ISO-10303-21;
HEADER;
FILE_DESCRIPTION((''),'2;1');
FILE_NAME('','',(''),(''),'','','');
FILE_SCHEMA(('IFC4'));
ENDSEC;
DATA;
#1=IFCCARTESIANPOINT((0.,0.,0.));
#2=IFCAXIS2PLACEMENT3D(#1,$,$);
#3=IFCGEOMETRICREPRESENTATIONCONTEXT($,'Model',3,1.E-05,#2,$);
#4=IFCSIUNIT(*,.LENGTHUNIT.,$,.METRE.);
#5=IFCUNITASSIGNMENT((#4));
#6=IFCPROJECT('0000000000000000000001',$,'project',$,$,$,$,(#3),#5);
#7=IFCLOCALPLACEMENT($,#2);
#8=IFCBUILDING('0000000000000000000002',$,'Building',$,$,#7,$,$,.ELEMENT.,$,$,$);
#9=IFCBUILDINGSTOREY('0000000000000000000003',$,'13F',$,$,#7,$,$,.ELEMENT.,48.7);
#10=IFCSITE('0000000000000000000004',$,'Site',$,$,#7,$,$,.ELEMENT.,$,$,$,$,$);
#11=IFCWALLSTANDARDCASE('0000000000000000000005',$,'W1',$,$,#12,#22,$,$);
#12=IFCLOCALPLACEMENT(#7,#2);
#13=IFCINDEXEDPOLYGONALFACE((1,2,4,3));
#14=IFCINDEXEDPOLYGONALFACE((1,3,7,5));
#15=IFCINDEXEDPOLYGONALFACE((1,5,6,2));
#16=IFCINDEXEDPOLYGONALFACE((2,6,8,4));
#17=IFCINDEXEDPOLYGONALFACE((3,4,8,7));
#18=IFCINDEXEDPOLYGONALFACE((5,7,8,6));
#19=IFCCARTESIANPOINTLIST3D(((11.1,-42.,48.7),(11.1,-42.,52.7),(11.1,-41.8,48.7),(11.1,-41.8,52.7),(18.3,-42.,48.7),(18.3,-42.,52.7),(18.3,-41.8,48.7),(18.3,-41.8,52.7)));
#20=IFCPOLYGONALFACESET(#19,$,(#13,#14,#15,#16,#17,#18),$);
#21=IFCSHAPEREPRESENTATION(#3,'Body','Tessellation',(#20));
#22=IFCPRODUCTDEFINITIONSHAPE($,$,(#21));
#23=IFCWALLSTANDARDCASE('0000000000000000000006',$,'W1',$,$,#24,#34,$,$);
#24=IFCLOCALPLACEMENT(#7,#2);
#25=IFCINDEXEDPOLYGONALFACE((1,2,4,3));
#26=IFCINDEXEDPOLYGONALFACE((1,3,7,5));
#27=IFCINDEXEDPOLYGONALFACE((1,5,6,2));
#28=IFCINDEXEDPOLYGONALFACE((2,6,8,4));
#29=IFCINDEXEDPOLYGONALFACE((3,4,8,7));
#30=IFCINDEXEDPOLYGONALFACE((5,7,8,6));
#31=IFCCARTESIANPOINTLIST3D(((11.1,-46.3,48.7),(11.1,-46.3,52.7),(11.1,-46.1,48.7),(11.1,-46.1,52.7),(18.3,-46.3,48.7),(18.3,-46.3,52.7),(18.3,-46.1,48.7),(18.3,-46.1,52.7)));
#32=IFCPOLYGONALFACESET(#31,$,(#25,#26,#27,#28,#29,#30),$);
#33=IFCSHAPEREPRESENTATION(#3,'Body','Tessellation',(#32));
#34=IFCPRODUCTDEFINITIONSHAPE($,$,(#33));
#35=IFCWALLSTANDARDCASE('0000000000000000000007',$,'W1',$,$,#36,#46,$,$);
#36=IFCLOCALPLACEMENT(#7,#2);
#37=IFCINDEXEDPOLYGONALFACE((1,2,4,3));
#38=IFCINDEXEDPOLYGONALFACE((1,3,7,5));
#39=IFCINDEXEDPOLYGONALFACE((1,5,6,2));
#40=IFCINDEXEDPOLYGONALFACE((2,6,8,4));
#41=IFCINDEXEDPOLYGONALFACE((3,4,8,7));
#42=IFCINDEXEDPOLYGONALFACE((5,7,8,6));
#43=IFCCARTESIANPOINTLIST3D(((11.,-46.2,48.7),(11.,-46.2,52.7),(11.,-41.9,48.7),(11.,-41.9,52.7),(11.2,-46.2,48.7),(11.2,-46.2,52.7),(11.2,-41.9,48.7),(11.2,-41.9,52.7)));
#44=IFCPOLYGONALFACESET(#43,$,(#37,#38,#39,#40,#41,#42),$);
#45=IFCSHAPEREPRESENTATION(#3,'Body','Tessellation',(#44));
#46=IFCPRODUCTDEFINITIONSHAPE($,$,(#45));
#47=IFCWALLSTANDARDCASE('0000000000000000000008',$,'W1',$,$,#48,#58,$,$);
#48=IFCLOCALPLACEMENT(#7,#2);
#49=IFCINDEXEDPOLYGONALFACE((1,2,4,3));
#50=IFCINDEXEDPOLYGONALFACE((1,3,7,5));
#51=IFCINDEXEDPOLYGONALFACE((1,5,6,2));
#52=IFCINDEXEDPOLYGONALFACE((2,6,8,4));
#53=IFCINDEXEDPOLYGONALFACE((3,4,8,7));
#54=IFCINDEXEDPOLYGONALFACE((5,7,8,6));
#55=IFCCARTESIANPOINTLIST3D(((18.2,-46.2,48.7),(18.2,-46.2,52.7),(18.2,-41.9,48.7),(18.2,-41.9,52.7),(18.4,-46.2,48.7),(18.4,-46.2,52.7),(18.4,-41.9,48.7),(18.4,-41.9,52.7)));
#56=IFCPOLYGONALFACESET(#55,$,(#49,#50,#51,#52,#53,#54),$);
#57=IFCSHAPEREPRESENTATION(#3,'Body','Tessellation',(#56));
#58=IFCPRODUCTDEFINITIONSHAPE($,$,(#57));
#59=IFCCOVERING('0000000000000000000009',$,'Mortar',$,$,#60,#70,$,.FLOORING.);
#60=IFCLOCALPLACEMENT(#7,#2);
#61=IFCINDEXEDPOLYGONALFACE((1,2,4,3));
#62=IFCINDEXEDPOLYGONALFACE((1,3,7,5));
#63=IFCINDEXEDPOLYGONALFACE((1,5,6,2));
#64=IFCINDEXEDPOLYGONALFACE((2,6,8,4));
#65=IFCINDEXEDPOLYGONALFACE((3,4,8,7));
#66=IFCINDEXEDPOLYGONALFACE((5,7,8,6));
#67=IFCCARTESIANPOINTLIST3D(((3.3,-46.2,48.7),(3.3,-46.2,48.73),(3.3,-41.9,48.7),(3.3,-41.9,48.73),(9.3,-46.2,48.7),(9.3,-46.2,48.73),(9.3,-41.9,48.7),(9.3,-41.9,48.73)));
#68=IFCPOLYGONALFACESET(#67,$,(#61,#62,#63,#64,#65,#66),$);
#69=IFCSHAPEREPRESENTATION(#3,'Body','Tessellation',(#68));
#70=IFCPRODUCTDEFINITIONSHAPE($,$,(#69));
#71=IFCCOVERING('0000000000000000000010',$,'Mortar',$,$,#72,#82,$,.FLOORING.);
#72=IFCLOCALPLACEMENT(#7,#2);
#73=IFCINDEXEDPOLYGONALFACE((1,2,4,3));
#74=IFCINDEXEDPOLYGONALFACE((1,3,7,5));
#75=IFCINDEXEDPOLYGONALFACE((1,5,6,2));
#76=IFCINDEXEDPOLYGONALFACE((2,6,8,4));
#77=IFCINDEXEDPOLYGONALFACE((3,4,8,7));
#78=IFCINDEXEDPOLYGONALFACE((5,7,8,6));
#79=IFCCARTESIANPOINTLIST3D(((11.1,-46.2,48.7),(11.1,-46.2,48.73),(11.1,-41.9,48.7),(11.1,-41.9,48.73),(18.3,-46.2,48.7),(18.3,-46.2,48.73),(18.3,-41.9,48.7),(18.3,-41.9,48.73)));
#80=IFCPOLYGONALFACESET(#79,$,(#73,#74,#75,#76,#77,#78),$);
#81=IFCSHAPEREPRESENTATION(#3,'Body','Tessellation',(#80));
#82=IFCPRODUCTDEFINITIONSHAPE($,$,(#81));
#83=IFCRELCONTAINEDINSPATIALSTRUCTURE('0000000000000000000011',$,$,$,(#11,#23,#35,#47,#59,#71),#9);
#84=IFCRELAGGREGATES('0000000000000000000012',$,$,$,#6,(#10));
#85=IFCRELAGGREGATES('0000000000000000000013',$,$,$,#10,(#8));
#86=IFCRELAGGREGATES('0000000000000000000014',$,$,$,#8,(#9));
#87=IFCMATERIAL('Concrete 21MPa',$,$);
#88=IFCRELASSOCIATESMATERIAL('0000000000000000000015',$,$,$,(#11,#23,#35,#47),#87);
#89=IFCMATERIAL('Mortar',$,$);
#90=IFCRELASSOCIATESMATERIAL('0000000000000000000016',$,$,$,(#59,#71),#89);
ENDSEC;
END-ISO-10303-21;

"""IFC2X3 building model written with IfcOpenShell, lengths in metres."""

from ifc_helpers import new_model, si_unit, frame, origin, origin_2d, place, context, project, spatial, rectangle, extrude, material, element, save


model = new_model("IFC2X3")

# Units and contexts
model_context = context("Model", 3, precision=1e-05, world=origin())
ifc_project = project(units=[si_unit("LENGTHUNIT", "METRE")], contexts=[model_context])

# Site, building, storey
placement = place(None, origin())
site = spatial("IfcSite", under=ifc_project, at=placement, Name="Site", CompositionType="ELEMENT")
building = spatial("IfcBuilding", under=site, at=placement, Name="Building", CompositionType="ELEMENT")
storey = spatial("IfcBuildingStorey", under=building, at=placement, Name="13F", CompositionType="ELEMENT", Elevation=48.7)

# Shared definitions
ifc_material_1 = material(Name="Concrete 21MPa")

# Walls
for number, where, name in (
    (1, (14.7, -41.9, 48.7), "W1"),
    (2, (14.7, -46.2, 48.7), "W1"),
):
    element("IfcWallStandardCase", number, at=place(None, frame(where)), inside=storey, material=ifc_material_1, Name=name, context=model_context, shape_type="SweptSolid", body=[
        extrude(rectangle(XDim=7.2, YDim=0.2, at=origin_2d()), origin(), (0.0, 0.0, 1.0), 4.0),
    ])
for number, where, name in (
    (3, (11.1, -44.05, 48.7), "W1"),
    (4, (18.3, -44.05, 48.7), "W1"),
):
    element("IfcWallStandardCase", number, at=place(None, frame(where)), inside=storey, material=ifc_material_1, Name=name, context=model_context, shape_type="SweptSolid", body=[
        extrude(rectangle(XDim=0.2, YDim=4.3, at=origin_2d()), origin(), (0.0, 0.0, 1.0), 4.0),
    ])

# Coverings
ifc_material_2 = material(Name="Mortar")
covering_1_placement = place(None, frame((6.3, -44.05, 48.7)))
element("IfcCovering", 5, at=covering_1_placement, inside=storey, material=ifc_material_2, Name="Mortar", PredefinedType="FLOORING", context=model_context, shape_type="SweptSolid", body=[
    extrude(rectangle(XDim=6.0, YDim=4.3, at=origin_2d()), origin(), (0.0, 0.0, 1.0), 0.03),
])
covering_2_placement = place(None, frame((14.7, -44.05, 48.7)))
element("IfcCovering", 6, at=covering_2_placement, inside=storey, material=ifc_material_2, Name="Mortar", PredefinedType="FLOORING", context=model_context, shape_type="SweptSolid", body=[
    extrude(rectangle(XDim=7.2, YDim=4.3, at=origin_2d()), origin(), (0.0, 0.0, 1.0), 0.03),
])

save(model, "model.ifc")
